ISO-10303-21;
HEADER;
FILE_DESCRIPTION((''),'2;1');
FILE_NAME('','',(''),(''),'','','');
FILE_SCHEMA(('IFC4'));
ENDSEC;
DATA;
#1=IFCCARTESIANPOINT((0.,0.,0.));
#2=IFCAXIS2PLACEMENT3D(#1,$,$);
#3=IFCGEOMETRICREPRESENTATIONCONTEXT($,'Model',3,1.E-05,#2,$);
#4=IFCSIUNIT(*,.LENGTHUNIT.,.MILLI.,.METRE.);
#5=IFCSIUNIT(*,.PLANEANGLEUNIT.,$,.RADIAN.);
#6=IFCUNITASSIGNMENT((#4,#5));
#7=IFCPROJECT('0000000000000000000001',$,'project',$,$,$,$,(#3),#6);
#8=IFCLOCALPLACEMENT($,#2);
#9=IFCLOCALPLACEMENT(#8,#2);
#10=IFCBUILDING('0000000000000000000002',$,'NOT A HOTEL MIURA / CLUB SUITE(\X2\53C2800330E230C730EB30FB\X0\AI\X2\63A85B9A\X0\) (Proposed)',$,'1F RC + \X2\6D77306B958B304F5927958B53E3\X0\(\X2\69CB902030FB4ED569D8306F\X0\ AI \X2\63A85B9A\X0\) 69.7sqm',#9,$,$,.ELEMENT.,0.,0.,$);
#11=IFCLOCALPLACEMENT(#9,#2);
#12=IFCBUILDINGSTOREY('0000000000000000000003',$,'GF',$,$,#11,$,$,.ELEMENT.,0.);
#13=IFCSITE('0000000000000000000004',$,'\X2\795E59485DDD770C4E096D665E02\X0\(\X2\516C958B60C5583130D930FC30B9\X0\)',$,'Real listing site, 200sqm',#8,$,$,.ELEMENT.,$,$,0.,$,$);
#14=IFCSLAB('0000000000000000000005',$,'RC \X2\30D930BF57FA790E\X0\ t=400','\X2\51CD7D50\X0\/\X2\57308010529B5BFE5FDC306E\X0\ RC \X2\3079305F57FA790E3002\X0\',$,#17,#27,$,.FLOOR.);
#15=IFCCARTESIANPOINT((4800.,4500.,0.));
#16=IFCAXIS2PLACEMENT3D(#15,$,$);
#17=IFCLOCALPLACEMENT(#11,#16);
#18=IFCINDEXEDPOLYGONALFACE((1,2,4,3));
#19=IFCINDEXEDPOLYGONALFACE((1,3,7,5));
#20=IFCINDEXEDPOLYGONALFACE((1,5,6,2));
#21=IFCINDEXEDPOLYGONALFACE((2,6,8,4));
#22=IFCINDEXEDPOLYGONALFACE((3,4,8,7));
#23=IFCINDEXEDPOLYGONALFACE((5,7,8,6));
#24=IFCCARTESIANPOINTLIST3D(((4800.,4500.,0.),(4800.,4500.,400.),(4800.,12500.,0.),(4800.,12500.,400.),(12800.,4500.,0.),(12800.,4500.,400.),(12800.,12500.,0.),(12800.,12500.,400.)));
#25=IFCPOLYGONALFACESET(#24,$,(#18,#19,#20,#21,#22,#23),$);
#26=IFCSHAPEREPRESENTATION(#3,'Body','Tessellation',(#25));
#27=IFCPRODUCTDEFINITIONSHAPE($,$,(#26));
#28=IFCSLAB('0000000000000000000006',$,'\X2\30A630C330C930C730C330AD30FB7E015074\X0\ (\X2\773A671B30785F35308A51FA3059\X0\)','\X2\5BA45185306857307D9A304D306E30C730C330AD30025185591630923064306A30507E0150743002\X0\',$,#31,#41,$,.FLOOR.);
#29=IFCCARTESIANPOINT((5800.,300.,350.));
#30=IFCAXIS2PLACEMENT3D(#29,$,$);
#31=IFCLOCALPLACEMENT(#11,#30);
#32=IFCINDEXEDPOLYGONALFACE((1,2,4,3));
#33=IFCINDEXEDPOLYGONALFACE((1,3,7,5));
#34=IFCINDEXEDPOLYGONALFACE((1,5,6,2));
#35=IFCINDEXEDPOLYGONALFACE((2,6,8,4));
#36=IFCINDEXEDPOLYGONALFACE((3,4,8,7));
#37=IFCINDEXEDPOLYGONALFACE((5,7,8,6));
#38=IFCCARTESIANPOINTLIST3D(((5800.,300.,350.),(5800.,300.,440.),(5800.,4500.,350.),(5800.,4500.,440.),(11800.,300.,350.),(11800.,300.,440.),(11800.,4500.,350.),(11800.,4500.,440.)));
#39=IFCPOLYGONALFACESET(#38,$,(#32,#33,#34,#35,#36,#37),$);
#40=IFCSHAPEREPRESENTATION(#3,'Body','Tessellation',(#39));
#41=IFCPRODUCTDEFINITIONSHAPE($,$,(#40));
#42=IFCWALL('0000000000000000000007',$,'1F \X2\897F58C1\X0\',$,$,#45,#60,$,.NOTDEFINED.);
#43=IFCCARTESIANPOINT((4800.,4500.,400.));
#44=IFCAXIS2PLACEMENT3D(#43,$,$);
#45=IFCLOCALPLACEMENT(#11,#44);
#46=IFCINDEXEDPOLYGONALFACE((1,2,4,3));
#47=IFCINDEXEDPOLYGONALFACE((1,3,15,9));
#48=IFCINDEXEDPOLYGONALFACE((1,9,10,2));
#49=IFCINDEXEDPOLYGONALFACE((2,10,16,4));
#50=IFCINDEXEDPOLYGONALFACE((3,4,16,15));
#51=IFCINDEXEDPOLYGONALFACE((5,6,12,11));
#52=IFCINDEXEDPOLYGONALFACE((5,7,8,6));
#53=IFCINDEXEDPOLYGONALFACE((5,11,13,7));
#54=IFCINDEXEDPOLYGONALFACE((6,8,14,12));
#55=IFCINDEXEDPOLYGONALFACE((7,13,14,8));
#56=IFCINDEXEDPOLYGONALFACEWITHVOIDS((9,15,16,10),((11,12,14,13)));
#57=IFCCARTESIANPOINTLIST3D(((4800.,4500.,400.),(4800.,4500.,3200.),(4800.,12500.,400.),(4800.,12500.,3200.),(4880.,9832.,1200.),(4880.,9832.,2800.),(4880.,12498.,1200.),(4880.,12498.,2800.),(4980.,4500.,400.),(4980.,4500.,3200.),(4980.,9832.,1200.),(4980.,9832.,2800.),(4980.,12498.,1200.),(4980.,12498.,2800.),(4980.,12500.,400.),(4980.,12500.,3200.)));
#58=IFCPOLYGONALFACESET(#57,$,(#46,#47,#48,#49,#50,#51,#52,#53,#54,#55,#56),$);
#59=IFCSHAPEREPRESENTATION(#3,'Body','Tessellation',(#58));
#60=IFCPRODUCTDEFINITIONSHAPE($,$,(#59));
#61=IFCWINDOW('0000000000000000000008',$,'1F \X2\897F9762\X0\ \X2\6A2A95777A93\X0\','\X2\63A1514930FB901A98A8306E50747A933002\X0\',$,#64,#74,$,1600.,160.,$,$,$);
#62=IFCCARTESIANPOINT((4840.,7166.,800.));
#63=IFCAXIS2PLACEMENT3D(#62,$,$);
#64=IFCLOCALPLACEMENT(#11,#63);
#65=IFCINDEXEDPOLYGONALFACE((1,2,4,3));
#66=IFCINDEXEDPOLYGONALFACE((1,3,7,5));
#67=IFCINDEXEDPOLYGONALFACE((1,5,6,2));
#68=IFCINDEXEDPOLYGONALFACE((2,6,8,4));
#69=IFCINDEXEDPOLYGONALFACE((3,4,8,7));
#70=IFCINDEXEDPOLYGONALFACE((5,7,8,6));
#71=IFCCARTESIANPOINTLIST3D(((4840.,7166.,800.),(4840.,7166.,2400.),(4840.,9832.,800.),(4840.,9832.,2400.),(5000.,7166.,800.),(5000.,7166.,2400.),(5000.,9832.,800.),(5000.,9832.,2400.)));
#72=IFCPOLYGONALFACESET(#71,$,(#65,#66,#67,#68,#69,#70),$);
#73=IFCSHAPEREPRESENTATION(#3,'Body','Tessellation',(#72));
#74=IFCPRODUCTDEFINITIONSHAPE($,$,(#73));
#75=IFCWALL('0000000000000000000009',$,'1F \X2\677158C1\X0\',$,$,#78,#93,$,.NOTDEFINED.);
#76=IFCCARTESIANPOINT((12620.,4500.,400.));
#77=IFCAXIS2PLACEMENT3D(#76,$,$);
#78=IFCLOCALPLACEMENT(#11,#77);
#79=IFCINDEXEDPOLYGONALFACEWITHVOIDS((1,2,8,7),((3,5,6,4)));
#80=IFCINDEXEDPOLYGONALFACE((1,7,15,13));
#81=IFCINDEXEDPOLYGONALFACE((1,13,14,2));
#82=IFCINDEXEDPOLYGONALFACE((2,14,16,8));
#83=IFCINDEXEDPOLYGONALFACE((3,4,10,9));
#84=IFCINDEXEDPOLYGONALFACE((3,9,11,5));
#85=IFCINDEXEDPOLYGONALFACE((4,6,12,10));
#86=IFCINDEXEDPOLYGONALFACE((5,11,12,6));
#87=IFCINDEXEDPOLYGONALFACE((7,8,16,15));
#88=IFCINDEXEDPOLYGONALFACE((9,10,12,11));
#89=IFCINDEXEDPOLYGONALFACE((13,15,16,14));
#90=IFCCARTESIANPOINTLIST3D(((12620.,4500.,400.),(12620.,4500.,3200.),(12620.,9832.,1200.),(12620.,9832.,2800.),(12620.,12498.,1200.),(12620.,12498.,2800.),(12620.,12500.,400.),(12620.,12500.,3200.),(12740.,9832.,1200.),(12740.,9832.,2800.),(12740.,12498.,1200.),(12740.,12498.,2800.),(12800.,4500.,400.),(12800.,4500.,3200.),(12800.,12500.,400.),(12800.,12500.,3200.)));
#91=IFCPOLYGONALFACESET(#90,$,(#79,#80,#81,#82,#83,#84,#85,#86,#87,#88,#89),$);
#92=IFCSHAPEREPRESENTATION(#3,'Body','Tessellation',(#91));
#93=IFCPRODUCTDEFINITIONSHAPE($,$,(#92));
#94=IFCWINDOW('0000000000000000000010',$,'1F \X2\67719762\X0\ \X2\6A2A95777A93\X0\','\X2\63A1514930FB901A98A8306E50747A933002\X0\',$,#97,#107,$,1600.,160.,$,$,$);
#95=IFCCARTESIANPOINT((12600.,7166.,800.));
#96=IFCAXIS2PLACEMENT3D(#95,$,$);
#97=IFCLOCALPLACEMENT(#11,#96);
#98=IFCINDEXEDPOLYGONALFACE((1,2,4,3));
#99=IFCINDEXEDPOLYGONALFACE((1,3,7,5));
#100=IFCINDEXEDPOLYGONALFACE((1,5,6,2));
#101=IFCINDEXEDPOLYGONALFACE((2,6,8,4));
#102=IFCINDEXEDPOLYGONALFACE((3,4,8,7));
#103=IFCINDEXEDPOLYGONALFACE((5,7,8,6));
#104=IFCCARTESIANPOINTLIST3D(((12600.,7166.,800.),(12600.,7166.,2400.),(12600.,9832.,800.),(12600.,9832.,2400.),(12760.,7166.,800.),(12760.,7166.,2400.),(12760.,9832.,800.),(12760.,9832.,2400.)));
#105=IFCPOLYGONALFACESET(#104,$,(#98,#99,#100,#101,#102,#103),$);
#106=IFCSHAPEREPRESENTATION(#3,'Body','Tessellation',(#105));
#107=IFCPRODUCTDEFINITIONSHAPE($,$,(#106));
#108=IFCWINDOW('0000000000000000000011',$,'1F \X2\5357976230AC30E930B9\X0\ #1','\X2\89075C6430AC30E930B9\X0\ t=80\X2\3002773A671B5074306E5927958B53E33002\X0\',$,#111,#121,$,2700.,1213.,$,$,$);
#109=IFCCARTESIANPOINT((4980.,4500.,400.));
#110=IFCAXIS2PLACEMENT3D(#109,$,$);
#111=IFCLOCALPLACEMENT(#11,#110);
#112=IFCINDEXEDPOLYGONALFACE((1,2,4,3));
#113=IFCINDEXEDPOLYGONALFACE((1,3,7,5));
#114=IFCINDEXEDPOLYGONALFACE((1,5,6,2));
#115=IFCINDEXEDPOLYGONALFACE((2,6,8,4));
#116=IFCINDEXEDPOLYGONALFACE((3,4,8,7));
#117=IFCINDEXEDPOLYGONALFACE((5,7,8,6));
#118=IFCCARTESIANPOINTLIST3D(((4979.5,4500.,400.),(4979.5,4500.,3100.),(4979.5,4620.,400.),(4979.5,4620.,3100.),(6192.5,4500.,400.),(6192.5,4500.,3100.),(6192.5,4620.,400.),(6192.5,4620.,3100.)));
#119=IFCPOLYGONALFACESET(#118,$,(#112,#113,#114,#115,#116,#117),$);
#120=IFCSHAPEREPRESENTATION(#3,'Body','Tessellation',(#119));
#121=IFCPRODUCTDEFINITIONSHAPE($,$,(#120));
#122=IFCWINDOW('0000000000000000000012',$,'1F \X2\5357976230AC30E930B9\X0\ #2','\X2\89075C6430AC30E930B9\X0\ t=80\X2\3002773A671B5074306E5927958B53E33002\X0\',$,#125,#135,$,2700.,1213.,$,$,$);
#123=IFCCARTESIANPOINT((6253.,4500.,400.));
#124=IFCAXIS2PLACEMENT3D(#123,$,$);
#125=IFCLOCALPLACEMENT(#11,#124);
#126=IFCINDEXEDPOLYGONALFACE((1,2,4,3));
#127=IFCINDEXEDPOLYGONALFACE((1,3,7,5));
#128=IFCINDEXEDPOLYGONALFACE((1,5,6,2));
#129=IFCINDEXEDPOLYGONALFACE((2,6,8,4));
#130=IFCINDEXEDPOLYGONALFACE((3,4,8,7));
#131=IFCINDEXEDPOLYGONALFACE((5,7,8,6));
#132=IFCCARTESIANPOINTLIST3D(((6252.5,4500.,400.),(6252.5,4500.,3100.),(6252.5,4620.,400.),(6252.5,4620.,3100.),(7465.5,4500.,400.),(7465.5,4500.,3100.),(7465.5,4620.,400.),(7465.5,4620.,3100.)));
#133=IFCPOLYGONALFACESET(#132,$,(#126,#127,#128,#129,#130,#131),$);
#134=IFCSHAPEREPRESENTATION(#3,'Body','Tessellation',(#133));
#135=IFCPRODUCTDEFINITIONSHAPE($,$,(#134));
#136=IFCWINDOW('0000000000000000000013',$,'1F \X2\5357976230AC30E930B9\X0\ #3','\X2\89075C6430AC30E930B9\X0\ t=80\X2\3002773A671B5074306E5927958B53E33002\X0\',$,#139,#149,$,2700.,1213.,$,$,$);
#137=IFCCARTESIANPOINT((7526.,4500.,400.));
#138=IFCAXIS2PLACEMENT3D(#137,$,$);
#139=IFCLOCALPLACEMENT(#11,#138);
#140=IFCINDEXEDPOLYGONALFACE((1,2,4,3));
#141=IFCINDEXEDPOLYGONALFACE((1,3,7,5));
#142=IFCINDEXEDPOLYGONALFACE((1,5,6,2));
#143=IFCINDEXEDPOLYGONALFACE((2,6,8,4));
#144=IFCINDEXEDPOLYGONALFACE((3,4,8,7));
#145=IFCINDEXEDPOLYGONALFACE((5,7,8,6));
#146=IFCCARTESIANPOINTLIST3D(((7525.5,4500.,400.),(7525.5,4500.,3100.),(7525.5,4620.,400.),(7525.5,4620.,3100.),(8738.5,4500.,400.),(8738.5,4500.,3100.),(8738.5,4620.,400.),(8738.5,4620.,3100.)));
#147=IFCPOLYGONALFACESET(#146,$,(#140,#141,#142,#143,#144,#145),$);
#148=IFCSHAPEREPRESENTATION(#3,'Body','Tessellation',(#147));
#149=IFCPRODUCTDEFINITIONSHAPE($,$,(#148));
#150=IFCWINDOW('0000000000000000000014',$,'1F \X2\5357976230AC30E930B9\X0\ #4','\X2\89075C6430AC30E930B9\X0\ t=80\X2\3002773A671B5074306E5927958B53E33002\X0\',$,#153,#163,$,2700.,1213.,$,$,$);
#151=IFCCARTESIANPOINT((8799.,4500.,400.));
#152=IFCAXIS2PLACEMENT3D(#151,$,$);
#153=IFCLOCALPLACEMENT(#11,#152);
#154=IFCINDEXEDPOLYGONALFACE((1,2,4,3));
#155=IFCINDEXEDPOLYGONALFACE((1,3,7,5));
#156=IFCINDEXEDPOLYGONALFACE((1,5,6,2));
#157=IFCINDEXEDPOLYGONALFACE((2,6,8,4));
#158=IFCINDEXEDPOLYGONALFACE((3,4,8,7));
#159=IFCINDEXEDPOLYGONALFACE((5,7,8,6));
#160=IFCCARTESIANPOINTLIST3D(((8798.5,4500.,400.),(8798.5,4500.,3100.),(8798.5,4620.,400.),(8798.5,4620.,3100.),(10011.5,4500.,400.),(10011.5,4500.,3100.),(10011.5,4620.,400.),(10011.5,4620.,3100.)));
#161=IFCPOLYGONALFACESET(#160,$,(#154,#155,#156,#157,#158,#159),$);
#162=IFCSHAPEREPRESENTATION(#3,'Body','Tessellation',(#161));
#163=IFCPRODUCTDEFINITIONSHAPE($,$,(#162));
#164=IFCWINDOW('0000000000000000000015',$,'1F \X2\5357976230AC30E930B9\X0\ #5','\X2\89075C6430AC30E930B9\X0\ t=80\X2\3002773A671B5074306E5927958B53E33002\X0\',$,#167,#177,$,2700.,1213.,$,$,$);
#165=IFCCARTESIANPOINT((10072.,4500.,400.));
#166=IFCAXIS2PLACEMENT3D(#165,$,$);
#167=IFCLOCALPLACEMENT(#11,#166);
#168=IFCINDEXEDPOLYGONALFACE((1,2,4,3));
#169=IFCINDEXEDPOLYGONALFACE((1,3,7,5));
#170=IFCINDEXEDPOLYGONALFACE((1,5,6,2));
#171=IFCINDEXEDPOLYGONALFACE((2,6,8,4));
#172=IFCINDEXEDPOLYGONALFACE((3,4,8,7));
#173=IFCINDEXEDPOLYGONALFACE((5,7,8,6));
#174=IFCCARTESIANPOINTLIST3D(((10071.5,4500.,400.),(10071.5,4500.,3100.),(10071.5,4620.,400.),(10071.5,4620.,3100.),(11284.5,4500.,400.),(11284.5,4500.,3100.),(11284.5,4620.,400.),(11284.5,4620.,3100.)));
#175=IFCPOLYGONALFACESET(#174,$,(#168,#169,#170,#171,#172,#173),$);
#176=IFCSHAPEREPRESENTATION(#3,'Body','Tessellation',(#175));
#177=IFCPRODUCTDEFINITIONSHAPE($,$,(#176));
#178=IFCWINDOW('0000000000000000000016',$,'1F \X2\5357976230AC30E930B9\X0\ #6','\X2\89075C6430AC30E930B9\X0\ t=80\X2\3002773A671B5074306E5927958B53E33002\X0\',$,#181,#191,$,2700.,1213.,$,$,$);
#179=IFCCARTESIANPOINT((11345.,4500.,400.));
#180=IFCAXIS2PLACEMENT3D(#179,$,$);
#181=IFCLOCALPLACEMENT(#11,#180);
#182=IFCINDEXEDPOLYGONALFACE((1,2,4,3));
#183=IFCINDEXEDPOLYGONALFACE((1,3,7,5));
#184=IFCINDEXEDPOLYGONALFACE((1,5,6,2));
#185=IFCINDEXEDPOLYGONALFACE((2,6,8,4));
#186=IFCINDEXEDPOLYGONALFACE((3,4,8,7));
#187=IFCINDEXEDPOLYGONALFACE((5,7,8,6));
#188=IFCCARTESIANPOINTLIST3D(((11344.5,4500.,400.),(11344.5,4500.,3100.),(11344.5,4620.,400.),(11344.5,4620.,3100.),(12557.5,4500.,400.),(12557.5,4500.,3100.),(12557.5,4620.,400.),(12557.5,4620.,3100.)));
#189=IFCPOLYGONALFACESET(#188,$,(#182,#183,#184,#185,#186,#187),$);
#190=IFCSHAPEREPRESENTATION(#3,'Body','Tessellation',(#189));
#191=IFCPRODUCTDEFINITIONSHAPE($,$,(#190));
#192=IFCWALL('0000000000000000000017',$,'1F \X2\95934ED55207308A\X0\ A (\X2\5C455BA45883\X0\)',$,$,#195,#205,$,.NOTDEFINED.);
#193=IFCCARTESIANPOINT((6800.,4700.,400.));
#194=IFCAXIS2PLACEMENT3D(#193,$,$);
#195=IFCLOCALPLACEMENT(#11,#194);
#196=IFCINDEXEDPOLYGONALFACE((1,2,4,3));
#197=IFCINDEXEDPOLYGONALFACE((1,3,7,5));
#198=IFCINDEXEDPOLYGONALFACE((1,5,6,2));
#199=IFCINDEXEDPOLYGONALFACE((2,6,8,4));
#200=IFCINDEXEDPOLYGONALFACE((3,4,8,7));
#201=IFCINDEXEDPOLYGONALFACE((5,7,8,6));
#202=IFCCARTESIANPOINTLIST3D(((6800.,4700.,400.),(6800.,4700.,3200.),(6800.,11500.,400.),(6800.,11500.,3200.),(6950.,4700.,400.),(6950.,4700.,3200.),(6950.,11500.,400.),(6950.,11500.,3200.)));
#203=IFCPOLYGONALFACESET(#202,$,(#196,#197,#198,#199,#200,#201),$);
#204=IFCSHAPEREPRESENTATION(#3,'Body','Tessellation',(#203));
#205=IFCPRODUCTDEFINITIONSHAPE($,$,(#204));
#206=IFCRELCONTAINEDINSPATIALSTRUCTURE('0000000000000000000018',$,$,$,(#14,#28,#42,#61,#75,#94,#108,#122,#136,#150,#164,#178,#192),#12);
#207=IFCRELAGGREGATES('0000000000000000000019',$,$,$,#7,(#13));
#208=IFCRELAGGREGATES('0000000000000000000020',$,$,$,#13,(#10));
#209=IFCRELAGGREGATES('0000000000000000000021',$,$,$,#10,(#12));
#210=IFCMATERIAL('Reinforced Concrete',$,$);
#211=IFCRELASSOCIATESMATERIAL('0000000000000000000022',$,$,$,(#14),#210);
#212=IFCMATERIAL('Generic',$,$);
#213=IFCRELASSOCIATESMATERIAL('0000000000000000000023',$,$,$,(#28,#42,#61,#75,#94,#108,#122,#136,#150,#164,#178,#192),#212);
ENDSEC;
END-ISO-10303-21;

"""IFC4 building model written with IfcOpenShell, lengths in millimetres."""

from ifc_helpers import new_model, si_unit, frame, frame_2d, origin, place, context, project, spatial, rectangle, extrude, material, element, fill, save


model = new_model("IFC4")

# Units and contexts
model_context = context("Model", 3, precision=1e-05, world=origin())
ifc_project = project(units=[si_unit("LENGTHUNIT", "METRE", prefix="MILLI"), si_unit("PLANEANGLEUNIT", "RADIAN")], contexts=[model_context])

# Site, building, storey
site_placement = place(None, origin())
site = spatial("IfcSite", under=ifc_project, at=site_placement, Name="神奈川県三浦市(公開情報ベース)", ObjectType="Real listing site, 200sqm", CompositionType="ELEMENT", RefElevation=0.0)
building_placement = place(site_placement, origin())
building = spatial("IfcBuilding", under=site, at=building_placement, Name="NOT A HOTEL MIURA / CLUB SUITE(参考モデル・AI推定) (Proposed)", ObjectType="1F RC + 海に開く大開口(構造・仕様は AI 推定) 69.7sqm", CompositionType="ELEMENT", ElevationOfRefHeight=0.0, ElevationOfTerrain=0.0)
storey_placement = place(building_placement, origin())
storey = spatial("IfcBuildingStorey", under=building, at=storey_placement, Name="GF", CompositionType="ELEMENT", Elevation=0.0)

# Slabs
ifc_material_1 = material(Name="Reinforced Concrete")
slab_1_placement = place(storey_placement, frame((4800.0, 4500.0, 0.0)))
element("IfcSlab", 1, at=slab_1_placement, inside=storey, material=ifc_material_1, Name="RC ベタ基礎 t=400", Description="凍結/地耐力対応の RC べた基礎。", PredefinedType="FLOOR", context=model_context, shape_type="SweptSolid", body=[
    extrude(rectangle(XDim=8000.0, YDim=8000.0, at=frame_2d((4000.0, 4000.0))), frame((4800.0, 4500.0, 0.0)), (0.0, 0.0, 1.0), 400.0),
])
ifc_material_2 = material(Name="Generic")
slab_2_placement = place(storey_placement, frame((5800.0, 300.0, 350.0)))
element("IfcSlab", 2, at=slab_2_placement, inside=storey, material=ifc_material_2, Name="ウッドデッキ・縁側 (眺望へ張り出す)", Description="室内と地続きのデッキ。内外をつなぐ縁側。", PredefinedType="FLOOR", context=model_context, shape_type="SweptSolid", body=[
    extrude(rectangle(XDim=6000.0, YDim=4200.0, at=frame_2d((3000.0, 2100.0))), frame((5800.0, 300.0, 350.0)), (0.0, 0.0, 1.0), 90.0),
])

# Walls, openings, windows
wall_1_placement = place(storey_placement, frame((4800.0, 4500.0, 400.0)))
wall_1 = element("IfcWall", 3, at=wall_1_placement, inside=storey, material=ifc_material_2, Name="1F 西壁", PredefinedType="NOTDEFINED", context=model_context, shape_type="SweptSolid", body=[
    extrude(rectangle(XDim=180.0, YDim=8000.0, at=frame_2d((90.0, 4000.0))), frame((4800.0, 4500.0, 400.0)), (0.0, 0.0, 1.0), 2800.0),
])
opening_1_placement = place(storey_placement, frame((4840.0, 7166.0, 800.0)))
opening_1 = element("IfcOpeningElement", 4, at=opening_1_placement, cuts=wall_1, PredefinedType="NOTDEFINED", context=model_context, shape_type="SweptSolid", body=[
    extrude(rectangle(XDim=160.0, YDim=2666.0, at=frame_2d((80.0, 1333.0))), frame((4840.0, 7166.0, 800.0)), (0.0, 0.0, 1.0), 1600.0),
])
window_1_placement = place(storey_placement, frame((4840.0, 7166.0, 800.0)))
window_1 = element("IfcWindow", 5, at=window_1_placement, inside=storey, material=ifc_material_2, Name="1F 西面 横長窓", Description="採光・通風の側窓。", OverallHeight=1600.0, OverallWidth=160.0, context=model_context, shape_type="SweptSolid", body=[
    extrude(rectangle(XDim=160.0, YDim=2666.0, at=frame_2d((80.0, 1333.0))), frame((4840.0, 7166.0, 800.0)), (0.0, 0.0, 1.0), 1600.0),
])
fill(opening_1, window_1)
wall_2_placement = place(storey_placement, frame((12620.0, 4500.0, 400.0)))
wall_2 = element("IfcWall", 6, at=wall_2_placement, inside=storey, material=ifc_material_2, Name="1F 東壁", PredefinedType="NOTDEFINED", context=model_context, shape_type="SweptSolid", body=[
    extrude(rectangle(XDim=180.0, YDim=8000.0, at=frame_2d((90.0, 4000.0))), frame((12620.0, 4500.0, 400.0)), (0.0, 0.0, 1.0), 2800.0),
])
opening_2_placement = place(storey_placement, frame((12600.0, 7166.0, 800.0)))
opening_2 = element("IfcOpeningElement", 7, at=opening_2_placement, cuts=wall_2, PredefinedType="NOTDEFINED", context=model_context, shape_type="SweptSolid", body=[
    extrude(rectangle(XDim=160.0, YDim=2666.0, at=frame_2d((80.0, 1333.0))), frame((12600.0, 7166.0, 800.0)), (0.0, 0.0, 1.0), 1600.0),
])
window_2_placement = place(storey_placement, frame((12600.0, 7166.0, 800.0)))
window_2 = element("IfcWindow", 8, at=window_2_placement, inside=storey, material=ifc_material_2, Name="1F 東面 横長窓", Description="採光・通風の側窓。", OverallHeight=1600.0, OverallWidth=160.0, context=model_context, shape_type="SweptSolid", body=[
    extrude(rectangle(XDim=160.0, YDim=2666.0, at=frame_2d((80.0, 1333.0))), frame((12600.0, 7166.0, 800.0)), (0.0, 0.0, 1.0), 1600.0),
])
fill(opening_2, window_2)

# Windows
window_3_placement = place(storey_placement, frame((4980.0, 4500.0, 400.0)))
element("IfcWindow", 9, at=window_3_placement, inside=storey, material=ifc_material_2, Name="1F 南面ガラス #1", Description="複層ガラス t=80。眺望側の大開口。", OverallHeight=2700.0, OverallWidth=1213.0, context=model_context, shape_type="SweptSolid", body=[
    extrude(rectangle(XDim=1213.0, YDim=120.0, at=frame_2d((606.0, 60.0))), frame((4980.0, 4500.0, 400.0)), (0.0, 0.0, 1.0), 2700.0),
])
window_4_placement = place(storey_placement, frame((6253.0, 4500.0, 400.0)))
element("IfcWindow", 10, at=window_4_placement, inside=storey, material=ifc_material_2, Name="1F 南面ガラス #2", Description="複層ガラス t=80。眺望側の大開口。", OverallHeight=2700.0, OverallWidth=1213.0, context=model_context, shape_type="SweptSolid", body=[
    extrude(rectangle(XDim=1213.0, YDim=120.0, at=frame_2d((606.0, 60.0))), frame((6253.0, 4500.0, 400.0)), (0.0, 0.0, 1.0), 2700.0),
])
window_5_placement = place(storey_placement, frame((7526.0, 4500.0, 400.0)))
element("IfcWindow", 11, at=window_5_placement, inside=storey, material=ifc_material_2, Name="1F 南面ガラス #3", Description="複層ガラス t=80。眺望側の大開口。", OverallHeight=2700.0, OverallWidth=1213.0, context=model_context, shape_type="SweptSolid", body=[
    extrude(rectangle(XDim=1213.0, YDim=120.0, at=frame_2d((606.0, 60.0))), frame((7526.0, 4500.0, 400.0)), (0.0, 0.0, 1.0), 2700.0),
])
window_6_placement = place(storey_placement, frame((8799.0, 4500.0, 400.0)))
element("IfcWindow", 12, at=window_6_placement, inside=storey, material=ifc_material_2, Name="1F 南面ガラス #4", Description="複層ガラス t=80。眺望側の大開口。", OverallHeight=2700.0, OverallWidth=1213.0, context=model_context, shape_type="SweptSolid", body=[
    extrude(rectangle(XDim=1213.0, YDim=120.0, at=frame_2d((606.0, 60.0))), frame((8799.0, 4500.0, 400.0)), (0.0, 0.0, 1.0), 2700.0),
])
window_7_placement = place(storey_placement, frame((10072.0, 4500.0, 400.0)))
element("IfcWindow", 13, at=window_7_placement, inside=storey, material=ifc_material_2, Name="1F 南面ガラス #5", Description="複層ガラス t=80。眺望側の大開口。", OverallHeight=2700.0, OverallWidth=1213.0, context=model_context, shape_type="SweptSolid", body=[
    extrude(rectangle(XDim=1213.0, YDim=120.0, at=frame_2d((606.0, 60.0))), frame((10072.0, 4500.0, 400.0)), (0.0, 0.0, 1.0), 2700.0),
])
window_8_placement = place(storey_placement, frame((11345.0, 4500.0, 400.0)))
element("IfcWindow", 14, at=window_8_placement, inside=storey, material=ifc_material_2, Name="1F 南面ガラス #6", Description="複層ガラス t=80。眺望側の大開口。", OverallHeight=2700.0, OverallWidth=1213.0, context=model_context, shape_type="SweptSolid", body=[
    extrude(rectangle(XDim=1213.0, YDim=120.0, at=frame_2d((606.0, 60.0))), frame((11345.0, 4500.0, 400.0)), (0.0, 0.0, 1.0), 2700.0),
])

# Wall
wall_3_placement = place(storey_placement, frame((6800.0, 4700.0, 400.0)))
element("IfcWall", 15, at=wall_3_placement, inside=storey, material=ifc_material_2, Name="1F 間仕切り A (居室境)", PredefinedType="NOTDEFINED", context=model_context, shape_type="SweptSolid", body=[
    extrude(rectangle(XDim=150.0, YDim=6800.0, at=frame_2d((75.0, 3400.0))), frame((6800.0, 4700.0, 400.0)), (0.0, 0.0, 1.0), 2800.0),
])

save(model, "model.ifc")
